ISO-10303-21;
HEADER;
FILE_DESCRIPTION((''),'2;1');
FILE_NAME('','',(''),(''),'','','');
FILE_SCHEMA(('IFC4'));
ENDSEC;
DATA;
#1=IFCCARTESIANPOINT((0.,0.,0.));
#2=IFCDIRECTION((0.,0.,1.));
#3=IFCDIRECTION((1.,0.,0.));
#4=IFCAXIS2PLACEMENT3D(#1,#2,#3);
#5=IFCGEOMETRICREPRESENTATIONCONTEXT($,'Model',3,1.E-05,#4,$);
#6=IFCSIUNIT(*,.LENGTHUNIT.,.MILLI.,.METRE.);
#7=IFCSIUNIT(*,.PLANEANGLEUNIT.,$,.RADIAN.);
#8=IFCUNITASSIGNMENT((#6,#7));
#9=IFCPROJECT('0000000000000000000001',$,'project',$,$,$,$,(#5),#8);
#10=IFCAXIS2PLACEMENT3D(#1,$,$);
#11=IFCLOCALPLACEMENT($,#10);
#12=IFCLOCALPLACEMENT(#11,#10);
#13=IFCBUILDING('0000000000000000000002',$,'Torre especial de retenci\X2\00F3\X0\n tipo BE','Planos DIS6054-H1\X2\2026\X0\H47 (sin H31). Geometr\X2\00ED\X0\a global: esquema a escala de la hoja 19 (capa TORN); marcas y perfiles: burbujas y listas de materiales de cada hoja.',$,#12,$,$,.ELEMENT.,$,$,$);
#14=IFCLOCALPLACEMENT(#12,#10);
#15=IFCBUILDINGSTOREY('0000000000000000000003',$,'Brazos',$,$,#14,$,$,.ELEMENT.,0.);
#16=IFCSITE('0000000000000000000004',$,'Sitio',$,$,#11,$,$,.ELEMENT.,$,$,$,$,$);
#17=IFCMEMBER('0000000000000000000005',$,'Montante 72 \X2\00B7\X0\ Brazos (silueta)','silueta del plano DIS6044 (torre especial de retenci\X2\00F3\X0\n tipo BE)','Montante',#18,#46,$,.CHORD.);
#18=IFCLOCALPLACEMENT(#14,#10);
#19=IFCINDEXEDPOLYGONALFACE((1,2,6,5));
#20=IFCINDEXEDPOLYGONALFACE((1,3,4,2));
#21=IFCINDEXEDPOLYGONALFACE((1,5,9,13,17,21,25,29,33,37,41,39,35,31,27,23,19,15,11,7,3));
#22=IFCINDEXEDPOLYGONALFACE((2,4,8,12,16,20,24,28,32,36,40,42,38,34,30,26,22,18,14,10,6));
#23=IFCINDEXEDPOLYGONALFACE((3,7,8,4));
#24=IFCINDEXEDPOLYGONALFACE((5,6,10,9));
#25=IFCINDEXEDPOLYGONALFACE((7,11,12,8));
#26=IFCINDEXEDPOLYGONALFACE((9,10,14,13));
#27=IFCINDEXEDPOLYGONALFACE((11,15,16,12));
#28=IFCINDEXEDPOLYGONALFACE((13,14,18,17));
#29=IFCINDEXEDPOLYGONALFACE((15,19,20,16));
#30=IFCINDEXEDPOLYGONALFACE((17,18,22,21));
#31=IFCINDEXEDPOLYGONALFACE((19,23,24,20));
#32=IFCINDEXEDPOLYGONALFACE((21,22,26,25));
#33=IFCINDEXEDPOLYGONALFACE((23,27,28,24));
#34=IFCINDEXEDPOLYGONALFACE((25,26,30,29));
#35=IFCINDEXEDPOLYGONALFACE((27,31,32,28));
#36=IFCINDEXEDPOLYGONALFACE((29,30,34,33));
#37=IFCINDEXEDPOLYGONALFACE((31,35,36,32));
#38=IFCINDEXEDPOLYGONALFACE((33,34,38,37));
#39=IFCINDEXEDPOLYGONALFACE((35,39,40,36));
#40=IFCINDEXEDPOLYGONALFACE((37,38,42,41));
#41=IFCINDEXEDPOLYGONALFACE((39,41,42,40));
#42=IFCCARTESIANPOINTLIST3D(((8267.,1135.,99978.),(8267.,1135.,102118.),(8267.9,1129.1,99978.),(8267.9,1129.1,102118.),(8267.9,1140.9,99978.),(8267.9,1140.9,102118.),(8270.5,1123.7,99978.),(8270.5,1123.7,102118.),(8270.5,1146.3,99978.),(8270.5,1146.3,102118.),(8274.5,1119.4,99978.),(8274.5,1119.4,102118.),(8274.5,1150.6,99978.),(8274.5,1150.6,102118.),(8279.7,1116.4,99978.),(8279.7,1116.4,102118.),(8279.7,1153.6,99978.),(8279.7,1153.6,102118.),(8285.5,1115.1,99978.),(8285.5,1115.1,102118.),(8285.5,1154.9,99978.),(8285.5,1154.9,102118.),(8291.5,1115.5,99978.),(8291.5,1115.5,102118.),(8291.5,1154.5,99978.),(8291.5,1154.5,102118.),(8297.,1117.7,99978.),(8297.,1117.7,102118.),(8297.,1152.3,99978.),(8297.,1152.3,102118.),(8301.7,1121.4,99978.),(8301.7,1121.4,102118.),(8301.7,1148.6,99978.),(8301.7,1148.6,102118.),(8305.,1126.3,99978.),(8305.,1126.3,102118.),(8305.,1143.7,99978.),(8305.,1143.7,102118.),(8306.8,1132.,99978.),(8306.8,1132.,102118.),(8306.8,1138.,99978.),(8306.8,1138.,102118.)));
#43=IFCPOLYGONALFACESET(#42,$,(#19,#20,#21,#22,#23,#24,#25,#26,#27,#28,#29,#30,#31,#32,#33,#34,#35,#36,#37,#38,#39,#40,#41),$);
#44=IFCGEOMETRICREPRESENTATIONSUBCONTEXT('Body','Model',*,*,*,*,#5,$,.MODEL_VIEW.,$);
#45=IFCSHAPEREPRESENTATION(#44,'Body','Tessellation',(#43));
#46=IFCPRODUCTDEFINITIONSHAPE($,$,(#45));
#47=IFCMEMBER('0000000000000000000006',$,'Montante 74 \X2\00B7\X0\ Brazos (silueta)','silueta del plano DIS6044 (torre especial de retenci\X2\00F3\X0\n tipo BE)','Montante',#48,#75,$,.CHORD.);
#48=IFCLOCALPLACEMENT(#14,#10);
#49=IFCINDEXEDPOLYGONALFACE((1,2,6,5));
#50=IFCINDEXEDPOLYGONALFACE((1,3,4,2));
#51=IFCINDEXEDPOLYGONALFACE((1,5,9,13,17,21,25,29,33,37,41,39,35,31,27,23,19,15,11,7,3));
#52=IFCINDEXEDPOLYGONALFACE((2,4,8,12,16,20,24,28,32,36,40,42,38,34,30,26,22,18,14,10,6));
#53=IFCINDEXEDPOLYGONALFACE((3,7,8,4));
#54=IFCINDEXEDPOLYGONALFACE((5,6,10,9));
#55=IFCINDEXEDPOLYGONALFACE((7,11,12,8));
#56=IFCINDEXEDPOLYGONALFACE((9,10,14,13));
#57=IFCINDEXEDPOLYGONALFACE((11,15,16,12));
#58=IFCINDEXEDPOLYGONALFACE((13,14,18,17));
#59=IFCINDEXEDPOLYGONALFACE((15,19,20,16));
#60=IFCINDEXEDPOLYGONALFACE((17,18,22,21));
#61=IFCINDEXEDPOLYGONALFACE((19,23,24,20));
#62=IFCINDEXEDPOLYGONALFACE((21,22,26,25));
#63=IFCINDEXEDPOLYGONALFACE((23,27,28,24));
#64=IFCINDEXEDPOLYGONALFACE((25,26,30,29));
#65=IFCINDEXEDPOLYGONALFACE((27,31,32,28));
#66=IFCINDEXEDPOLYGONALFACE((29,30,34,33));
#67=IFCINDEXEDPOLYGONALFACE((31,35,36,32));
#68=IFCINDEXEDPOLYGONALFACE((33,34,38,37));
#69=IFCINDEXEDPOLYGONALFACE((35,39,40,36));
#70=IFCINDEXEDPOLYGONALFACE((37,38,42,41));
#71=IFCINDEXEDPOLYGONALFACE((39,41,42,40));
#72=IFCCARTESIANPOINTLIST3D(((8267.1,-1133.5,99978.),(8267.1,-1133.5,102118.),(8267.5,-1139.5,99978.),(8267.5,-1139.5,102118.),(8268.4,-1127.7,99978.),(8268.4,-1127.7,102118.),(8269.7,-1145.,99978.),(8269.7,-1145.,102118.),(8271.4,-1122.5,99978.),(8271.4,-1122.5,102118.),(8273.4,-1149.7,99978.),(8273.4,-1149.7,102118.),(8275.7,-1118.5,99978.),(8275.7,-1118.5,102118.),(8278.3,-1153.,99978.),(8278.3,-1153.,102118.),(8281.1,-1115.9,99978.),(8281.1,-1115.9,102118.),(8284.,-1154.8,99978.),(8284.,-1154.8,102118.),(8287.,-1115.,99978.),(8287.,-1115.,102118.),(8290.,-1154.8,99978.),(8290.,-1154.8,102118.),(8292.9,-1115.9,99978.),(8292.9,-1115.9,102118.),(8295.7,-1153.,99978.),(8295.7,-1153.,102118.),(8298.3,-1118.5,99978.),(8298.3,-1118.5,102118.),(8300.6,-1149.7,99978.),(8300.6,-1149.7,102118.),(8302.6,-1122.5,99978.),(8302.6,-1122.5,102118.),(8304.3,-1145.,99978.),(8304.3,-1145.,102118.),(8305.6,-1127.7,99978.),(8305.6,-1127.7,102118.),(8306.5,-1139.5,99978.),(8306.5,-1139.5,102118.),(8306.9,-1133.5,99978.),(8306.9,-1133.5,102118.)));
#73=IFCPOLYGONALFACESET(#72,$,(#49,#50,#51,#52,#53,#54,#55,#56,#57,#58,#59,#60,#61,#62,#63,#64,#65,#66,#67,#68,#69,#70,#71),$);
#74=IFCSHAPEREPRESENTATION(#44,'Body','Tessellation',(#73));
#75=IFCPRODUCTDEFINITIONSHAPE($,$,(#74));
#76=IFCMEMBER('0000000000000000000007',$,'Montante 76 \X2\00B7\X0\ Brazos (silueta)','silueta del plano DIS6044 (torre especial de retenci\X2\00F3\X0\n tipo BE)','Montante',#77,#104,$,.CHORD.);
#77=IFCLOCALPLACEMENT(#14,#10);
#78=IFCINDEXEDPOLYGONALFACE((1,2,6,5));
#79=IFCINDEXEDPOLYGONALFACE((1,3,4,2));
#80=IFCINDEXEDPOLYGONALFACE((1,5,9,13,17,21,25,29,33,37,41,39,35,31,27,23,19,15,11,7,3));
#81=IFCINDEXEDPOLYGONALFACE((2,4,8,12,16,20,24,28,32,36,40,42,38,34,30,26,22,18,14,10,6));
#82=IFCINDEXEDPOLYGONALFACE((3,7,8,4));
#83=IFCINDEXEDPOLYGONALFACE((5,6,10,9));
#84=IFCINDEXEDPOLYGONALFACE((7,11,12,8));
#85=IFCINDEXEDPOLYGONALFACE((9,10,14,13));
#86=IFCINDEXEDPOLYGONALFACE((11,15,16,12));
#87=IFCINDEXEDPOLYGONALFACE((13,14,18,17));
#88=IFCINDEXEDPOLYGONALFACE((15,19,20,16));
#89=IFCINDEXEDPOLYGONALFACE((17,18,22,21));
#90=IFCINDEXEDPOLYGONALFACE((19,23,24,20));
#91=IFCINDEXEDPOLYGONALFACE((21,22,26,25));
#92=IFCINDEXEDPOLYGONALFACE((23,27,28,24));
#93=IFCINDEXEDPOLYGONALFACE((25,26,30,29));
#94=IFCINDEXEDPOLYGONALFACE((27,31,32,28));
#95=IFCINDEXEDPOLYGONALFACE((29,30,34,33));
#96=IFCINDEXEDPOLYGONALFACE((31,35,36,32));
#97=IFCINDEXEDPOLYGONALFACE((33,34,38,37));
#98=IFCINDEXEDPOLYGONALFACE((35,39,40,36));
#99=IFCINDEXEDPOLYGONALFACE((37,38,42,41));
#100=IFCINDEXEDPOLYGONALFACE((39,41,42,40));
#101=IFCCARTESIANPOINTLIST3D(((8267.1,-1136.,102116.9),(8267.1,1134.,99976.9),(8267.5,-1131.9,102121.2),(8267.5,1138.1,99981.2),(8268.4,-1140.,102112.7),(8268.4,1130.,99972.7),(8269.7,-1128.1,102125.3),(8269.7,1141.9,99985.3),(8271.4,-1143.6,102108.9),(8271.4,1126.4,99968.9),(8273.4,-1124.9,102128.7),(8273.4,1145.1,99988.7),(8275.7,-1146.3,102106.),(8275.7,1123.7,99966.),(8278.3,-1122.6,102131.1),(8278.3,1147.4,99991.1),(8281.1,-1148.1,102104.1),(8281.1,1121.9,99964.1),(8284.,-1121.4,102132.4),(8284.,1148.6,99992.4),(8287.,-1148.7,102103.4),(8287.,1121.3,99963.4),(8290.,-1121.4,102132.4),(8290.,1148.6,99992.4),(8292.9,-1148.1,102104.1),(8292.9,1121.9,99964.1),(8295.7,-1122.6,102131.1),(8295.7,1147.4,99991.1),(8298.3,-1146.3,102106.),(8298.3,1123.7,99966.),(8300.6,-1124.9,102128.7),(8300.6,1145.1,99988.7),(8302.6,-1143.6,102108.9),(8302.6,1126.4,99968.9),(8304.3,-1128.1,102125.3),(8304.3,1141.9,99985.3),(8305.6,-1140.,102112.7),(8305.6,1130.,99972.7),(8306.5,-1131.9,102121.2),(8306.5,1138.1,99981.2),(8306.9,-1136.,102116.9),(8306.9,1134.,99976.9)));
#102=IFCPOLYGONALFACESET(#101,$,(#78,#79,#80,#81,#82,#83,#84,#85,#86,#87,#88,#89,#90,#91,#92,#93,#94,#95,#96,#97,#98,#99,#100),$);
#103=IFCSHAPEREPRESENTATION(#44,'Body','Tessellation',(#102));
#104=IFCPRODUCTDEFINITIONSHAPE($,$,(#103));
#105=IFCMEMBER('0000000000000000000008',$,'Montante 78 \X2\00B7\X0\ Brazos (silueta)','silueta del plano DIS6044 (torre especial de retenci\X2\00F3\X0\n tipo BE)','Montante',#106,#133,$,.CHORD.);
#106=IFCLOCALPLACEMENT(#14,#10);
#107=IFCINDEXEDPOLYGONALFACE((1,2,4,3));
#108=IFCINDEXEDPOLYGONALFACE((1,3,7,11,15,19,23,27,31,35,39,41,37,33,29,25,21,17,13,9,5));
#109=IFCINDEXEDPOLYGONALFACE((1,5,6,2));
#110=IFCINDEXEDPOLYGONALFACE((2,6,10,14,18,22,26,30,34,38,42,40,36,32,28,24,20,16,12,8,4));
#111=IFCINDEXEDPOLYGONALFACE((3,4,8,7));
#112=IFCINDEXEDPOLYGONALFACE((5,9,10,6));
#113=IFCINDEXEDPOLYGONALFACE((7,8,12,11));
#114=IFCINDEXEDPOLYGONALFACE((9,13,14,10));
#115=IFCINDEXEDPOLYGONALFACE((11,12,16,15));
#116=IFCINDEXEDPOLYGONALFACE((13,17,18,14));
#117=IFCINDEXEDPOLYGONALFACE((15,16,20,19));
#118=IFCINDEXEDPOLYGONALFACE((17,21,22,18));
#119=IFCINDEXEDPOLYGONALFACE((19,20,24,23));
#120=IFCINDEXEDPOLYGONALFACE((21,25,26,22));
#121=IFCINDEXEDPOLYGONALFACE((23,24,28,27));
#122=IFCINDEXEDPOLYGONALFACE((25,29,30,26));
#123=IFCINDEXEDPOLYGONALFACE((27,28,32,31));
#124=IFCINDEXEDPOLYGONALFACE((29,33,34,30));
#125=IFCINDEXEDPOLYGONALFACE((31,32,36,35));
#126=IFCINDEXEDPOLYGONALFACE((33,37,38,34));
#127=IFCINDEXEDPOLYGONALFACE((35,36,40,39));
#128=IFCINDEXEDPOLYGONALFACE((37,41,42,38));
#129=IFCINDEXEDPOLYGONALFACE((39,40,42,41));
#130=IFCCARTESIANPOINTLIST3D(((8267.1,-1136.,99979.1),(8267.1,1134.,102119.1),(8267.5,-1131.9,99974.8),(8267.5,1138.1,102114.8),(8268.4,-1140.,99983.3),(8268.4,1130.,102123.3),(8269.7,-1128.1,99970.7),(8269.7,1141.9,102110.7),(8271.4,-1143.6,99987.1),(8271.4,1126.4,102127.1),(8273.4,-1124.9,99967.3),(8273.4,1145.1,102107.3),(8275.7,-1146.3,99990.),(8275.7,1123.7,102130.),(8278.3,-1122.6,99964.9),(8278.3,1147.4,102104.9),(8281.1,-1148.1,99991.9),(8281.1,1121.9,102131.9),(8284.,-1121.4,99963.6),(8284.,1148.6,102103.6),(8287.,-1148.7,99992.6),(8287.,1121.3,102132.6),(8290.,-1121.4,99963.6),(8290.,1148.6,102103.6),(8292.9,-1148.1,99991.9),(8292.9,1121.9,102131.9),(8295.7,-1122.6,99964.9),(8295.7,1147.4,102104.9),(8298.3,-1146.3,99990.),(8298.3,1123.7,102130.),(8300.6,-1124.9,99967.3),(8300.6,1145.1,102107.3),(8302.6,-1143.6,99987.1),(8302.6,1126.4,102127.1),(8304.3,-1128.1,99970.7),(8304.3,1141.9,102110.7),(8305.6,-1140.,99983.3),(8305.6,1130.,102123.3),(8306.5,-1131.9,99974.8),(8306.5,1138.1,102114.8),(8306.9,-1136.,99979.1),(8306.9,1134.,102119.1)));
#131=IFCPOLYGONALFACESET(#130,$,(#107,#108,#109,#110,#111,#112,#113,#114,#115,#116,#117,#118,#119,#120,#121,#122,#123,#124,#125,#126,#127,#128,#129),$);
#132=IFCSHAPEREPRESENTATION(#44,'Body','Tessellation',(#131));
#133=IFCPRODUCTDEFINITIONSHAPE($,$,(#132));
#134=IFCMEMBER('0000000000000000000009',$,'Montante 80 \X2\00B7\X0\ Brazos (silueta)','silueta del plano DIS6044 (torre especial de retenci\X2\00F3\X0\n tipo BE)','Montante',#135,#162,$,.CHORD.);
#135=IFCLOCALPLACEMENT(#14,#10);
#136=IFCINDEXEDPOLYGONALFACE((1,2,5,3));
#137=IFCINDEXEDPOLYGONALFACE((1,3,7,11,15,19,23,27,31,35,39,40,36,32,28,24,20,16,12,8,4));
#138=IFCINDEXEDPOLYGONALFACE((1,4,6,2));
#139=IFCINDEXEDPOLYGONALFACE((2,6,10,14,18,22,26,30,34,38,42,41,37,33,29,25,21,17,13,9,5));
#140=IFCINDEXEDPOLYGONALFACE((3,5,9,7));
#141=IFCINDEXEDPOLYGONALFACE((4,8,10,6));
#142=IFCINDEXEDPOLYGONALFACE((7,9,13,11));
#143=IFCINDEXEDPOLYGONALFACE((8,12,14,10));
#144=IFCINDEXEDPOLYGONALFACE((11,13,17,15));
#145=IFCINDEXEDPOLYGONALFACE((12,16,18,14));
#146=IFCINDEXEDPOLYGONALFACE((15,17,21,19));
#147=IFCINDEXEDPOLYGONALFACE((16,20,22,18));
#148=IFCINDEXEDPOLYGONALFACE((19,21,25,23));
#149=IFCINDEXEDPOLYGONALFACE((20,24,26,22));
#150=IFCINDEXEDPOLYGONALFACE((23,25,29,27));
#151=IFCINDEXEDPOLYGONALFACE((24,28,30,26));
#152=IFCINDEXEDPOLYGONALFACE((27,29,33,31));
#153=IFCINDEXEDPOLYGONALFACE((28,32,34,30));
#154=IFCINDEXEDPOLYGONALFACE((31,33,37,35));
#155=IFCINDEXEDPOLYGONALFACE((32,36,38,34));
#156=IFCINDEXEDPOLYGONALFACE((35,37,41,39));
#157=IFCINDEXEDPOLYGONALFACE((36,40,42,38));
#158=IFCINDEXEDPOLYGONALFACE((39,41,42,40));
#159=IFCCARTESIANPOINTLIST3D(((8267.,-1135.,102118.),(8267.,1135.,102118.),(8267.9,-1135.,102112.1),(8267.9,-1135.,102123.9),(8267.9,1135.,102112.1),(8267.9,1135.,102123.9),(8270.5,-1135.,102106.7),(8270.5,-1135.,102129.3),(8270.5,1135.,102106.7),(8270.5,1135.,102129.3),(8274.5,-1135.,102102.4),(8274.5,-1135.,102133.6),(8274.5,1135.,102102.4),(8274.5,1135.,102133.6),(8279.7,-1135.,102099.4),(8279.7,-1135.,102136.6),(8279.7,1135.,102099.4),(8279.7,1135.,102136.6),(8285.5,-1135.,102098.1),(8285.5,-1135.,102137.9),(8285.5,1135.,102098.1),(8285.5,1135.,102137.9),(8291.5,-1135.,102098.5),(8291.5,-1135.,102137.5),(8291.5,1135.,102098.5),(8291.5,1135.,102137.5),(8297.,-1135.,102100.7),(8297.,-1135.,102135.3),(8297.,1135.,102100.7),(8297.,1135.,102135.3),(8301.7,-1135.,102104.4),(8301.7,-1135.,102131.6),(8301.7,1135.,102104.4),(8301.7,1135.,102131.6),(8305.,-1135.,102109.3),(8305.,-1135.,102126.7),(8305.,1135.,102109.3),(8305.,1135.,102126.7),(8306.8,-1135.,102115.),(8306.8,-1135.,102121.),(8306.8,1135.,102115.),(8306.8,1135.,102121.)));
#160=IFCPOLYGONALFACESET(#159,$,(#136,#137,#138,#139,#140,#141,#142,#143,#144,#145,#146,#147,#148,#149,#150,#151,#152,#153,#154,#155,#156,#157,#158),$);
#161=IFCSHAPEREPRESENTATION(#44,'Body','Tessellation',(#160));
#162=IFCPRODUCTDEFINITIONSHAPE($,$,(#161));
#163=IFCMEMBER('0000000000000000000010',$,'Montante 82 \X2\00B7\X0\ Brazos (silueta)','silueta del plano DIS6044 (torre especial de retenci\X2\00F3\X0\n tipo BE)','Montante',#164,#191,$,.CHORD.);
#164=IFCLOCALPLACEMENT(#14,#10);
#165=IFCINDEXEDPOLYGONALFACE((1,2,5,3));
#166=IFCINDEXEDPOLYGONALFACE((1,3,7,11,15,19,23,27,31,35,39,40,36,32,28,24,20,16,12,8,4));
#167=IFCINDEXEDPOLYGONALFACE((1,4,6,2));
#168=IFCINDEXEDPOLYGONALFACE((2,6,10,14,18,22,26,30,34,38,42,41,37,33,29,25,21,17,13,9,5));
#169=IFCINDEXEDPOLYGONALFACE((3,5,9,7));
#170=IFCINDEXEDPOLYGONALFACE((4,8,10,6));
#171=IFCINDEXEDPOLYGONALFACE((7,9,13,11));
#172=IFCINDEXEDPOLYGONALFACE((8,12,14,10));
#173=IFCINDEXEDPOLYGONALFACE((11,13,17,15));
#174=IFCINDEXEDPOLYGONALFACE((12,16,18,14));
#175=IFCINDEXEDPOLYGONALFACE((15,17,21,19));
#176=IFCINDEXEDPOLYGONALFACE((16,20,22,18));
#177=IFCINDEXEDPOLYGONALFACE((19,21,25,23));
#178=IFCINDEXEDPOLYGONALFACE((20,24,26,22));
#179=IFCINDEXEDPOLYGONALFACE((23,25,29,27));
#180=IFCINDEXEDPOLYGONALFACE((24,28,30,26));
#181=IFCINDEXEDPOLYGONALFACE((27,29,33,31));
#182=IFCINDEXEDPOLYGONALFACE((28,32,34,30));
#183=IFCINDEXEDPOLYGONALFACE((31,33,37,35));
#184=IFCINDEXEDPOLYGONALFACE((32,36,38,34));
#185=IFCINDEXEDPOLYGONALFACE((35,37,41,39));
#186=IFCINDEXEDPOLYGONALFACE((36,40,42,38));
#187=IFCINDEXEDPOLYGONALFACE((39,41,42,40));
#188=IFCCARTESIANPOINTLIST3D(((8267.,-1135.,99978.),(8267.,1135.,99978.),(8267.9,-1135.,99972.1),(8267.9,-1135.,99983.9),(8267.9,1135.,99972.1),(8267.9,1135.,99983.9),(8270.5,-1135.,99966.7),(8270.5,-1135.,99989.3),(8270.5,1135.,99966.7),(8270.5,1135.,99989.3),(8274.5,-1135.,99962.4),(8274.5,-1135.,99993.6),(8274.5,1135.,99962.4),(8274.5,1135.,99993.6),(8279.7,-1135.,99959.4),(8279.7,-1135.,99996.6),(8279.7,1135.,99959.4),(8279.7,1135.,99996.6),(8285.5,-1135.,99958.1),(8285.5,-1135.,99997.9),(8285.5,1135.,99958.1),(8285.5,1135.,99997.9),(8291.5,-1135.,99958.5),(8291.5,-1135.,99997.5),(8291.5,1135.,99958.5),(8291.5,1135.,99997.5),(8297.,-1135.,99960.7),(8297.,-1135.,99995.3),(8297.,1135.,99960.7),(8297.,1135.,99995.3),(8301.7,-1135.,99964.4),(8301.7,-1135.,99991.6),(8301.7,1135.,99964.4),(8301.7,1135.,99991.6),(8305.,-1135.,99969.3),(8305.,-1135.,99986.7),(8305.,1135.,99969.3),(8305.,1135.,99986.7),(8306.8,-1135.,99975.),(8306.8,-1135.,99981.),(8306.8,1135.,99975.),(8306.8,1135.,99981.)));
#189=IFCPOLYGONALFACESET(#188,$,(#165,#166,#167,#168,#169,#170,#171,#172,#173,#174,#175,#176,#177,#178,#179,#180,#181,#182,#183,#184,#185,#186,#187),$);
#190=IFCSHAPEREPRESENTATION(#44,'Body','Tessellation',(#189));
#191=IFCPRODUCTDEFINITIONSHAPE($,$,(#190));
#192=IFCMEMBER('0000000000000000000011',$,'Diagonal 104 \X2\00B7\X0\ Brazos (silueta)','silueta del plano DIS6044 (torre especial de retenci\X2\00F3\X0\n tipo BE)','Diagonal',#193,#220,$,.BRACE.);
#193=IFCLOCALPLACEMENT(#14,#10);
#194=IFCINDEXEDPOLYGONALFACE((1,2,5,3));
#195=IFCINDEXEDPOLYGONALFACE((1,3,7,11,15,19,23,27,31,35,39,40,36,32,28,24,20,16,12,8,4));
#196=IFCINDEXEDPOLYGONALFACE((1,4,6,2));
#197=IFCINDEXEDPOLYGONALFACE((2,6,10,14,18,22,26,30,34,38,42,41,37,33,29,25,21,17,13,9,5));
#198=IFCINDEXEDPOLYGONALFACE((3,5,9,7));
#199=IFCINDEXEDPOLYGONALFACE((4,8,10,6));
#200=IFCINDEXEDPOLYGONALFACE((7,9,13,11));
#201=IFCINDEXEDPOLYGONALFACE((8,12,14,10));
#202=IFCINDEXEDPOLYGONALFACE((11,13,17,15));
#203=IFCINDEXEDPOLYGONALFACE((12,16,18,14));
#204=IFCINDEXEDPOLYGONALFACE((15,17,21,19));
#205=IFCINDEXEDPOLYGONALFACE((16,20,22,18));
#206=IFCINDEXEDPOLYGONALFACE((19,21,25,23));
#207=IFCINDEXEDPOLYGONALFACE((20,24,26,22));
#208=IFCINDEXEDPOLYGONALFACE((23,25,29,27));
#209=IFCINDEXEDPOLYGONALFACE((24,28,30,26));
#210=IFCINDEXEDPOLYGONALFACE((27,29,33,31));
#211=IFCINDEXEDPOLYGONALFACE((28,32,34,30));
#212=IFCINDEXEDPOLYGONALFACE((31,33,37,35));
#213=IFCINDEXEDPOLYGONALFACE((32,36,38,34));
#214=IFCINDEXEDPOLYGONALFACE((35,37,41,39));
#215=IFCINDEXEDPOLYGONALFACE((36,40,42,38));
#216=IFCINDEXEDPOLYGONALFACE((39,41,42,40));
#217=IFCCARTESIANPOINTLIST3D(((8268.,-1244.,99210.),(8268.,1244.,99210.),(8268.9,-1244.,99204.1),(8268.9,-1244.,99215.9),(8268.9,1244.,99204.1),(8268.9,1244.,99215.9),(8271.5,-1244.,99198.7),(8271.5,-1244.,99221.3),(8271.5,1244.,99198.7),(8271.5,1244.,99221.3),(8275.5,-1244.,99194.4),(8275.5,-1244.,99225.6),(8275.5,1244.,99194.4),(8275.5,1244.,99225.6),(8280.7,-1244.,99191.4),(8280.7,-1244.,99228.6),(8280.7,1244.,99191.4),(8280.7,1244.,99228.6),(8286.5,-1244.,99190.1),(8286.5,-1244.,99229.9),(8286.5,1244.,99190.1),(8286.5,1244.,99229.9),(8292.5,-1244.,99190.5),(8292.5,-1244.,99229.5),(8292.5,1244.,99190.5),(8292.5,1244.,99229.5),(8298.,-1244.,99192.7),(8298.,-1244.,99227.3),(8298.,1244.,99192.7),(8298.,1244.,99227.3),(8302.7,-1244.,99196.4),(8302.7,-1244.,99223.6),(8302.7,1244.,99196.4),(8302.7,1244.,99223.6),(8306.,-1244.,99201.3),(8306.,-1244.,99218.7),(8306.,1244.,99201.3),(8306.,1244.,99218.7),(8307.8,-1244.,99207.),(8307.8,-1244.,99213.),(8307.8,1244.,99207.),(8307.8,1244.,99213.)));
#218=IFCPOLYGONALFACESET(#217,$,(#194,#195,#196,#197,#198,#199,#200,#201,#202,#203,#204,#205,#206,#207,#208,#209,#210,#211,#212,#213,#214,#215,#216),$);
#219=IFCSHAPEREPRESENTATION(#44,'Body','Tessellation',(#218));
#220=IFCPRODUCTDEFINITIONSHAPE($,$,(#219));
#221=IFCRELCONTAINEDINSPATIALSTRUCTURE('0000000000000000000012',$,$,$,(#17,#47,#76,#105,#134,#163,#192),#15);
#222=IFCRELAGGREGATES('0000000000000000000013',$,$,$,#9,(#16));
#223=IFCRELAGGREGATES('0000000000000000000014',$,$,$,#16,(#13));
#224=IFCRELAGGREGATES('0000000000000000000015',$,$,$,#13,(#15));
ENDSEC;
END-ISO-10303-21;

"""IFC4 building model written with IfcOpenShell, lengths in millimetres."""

from ifc_helpers import new_model, si_unit, frame, origin, origin_with_axes, place, context, subcontext, project, spatial, circle, extrude, element, save


model = new_model("IFC4")

# Units and contexts
model_context = context("Model", 3, precision=1e-05, world=origin_with_axes())
body_context = subcontext(model_context, "Body", "Model", "MODEL_VIEW")
ifc_project = project(units=[si_unit("LENGTHUNIT", "METRE", prefix="MILLI"), si_unit("PLANEANGLEUNIT", "RADIAN")], contexts=[model_context])

# Site, building, storey
site_placement = place(None, origin())
site = spatial("IfcSite", under=ifc_project, at=site_placement, Name="Sitio", CompositionType="ELEMENT")
building_placement = place(site_placement, origin())
building = spatial("IfcBuilding", under=site, at=building_placement, Name="Torre especial de retención tipo BE", Description="Planos DIS6054-H1…H47 (sin H31). Geometría global: esquema a escala de la hoja 19 (capa TORN); marcas y perfiles: burbujas y listas de materiales de cada hoja.", CompositionType="ELEMENT")
storey_placement = place(building_placement, origin())
storey = spatial("IfcBuildingStorey", under=building, at=storey_placement, Name="Brazos", CompositionType="ELEMENT", Elevation=0.0)

# Members
for number, where, z_axis, x_axis, name in (
    (1, (8287.0, 1135.0, 99978.0), (0.0, 0.0, 1.0), (-1.0, 0.0, 0.0), "Montante 72 · Brazos (silueta)"),
    (2, (8287.0, -1135.0, 99978.0), (0.0, 0.0, 1.0), (0.0, 1.0, 0.0), "Montante 74 · Brazos (silueta)"),
):
    element("IfcMember", number, at=place(storey_placement, frame(where, z_axis=z_axis, x_axis=x_axis)), inside=storey, Name=name, Description="silueta del plano DIS6044 (torre especial de retención tipo BE)", ObjectType="Montante", PredefinedType="CHORD", context=body_context, shape_type="SweptSolid", body=[
        extrude(circle(Radius=20.0), None, (0.0, 0.0, 1.0), 2140.0),
    ])
for number, where, z_axis, x_axis, name in (
    (3, (8287.0, -1135.0, 102118.0), (0.0, 0.727635, -0.685964), (0.0, -0.685964, -0.727635), "Montante 76 · Brazos (silueta)"),
    (4, (8287.0, 1135.0, 102118.0), (0.0, -0.727635, -0.685964), (0.0, -0.685964, 0.727635), "Montante 78 · Brazos (silueta)"),
):
    element("IfcMember", number, at=place(storey_placement, frame(where, z_axis=z_axis, x_axis=x_axis)), inside=storey, Name=name, Description="silueta del plano DIS6044 (torre especial de retención tipo BE)", ObjectType="Montante", PredefinedType="CHORD", context=body_context, shape_type="SweptSolid", body=[
        extrude(circle(Radius=20.0), None, (0.0, 0.0, 1.0), 3119.7),
    ])
for number, where, z_axis, x_axis, name in (
    (5, (8287.0, 1135.0, 102118.0), (0.0, -1.0, 0.0), (-1.0, 0.0, 0.0), "Montante 80 · Brazos (silueta)"),
    (6, (8287.0, 1135.0, 99978.0), (0.0, -1.0, 0.0), (-1.0, 0.0, 0.0), "Montante 82 · Brazos (silueta)"),
):
    element("IfcMember", number, at=place(storey_placement, frame(where, z_axis=z_axis, x_axis=x_axis)), inside=storey, Name=name, Description="silueta del plano DIS6044 (torre especial de retención tipo BE)", ObjectType="Montante", PredefinedType="CHORD", context=body_context, shape_type="SweptSolid", body=[
        extrude(circle(Radius=20.0), None, (0.0, 0.0, 1.0), 2270.0),
    ])
member_1_placement = place(storey_placement, frame((8288.0, 1244.0, 99210.0), z_axis=(0.0, -1.0, 0.0), x_axis=(-1.0, 0.0, 0.0)))
element("IfcMember", 7, at=member_1_placement, inside=storey, Name="Diagonal 104 · Brazos (silueta)", Description="silueta del plano DIS6044 (torre especial de retención tipo BE)", ObjectType="Diagonal", PredefinedType="BRACE", context=body_context, shape_type="SweptSolid", body=[
    extrude(circle(Radius=20.0), None, (0.0, 0.0, 1.0), 2488.0),
])

save(model, "model.ifc")
